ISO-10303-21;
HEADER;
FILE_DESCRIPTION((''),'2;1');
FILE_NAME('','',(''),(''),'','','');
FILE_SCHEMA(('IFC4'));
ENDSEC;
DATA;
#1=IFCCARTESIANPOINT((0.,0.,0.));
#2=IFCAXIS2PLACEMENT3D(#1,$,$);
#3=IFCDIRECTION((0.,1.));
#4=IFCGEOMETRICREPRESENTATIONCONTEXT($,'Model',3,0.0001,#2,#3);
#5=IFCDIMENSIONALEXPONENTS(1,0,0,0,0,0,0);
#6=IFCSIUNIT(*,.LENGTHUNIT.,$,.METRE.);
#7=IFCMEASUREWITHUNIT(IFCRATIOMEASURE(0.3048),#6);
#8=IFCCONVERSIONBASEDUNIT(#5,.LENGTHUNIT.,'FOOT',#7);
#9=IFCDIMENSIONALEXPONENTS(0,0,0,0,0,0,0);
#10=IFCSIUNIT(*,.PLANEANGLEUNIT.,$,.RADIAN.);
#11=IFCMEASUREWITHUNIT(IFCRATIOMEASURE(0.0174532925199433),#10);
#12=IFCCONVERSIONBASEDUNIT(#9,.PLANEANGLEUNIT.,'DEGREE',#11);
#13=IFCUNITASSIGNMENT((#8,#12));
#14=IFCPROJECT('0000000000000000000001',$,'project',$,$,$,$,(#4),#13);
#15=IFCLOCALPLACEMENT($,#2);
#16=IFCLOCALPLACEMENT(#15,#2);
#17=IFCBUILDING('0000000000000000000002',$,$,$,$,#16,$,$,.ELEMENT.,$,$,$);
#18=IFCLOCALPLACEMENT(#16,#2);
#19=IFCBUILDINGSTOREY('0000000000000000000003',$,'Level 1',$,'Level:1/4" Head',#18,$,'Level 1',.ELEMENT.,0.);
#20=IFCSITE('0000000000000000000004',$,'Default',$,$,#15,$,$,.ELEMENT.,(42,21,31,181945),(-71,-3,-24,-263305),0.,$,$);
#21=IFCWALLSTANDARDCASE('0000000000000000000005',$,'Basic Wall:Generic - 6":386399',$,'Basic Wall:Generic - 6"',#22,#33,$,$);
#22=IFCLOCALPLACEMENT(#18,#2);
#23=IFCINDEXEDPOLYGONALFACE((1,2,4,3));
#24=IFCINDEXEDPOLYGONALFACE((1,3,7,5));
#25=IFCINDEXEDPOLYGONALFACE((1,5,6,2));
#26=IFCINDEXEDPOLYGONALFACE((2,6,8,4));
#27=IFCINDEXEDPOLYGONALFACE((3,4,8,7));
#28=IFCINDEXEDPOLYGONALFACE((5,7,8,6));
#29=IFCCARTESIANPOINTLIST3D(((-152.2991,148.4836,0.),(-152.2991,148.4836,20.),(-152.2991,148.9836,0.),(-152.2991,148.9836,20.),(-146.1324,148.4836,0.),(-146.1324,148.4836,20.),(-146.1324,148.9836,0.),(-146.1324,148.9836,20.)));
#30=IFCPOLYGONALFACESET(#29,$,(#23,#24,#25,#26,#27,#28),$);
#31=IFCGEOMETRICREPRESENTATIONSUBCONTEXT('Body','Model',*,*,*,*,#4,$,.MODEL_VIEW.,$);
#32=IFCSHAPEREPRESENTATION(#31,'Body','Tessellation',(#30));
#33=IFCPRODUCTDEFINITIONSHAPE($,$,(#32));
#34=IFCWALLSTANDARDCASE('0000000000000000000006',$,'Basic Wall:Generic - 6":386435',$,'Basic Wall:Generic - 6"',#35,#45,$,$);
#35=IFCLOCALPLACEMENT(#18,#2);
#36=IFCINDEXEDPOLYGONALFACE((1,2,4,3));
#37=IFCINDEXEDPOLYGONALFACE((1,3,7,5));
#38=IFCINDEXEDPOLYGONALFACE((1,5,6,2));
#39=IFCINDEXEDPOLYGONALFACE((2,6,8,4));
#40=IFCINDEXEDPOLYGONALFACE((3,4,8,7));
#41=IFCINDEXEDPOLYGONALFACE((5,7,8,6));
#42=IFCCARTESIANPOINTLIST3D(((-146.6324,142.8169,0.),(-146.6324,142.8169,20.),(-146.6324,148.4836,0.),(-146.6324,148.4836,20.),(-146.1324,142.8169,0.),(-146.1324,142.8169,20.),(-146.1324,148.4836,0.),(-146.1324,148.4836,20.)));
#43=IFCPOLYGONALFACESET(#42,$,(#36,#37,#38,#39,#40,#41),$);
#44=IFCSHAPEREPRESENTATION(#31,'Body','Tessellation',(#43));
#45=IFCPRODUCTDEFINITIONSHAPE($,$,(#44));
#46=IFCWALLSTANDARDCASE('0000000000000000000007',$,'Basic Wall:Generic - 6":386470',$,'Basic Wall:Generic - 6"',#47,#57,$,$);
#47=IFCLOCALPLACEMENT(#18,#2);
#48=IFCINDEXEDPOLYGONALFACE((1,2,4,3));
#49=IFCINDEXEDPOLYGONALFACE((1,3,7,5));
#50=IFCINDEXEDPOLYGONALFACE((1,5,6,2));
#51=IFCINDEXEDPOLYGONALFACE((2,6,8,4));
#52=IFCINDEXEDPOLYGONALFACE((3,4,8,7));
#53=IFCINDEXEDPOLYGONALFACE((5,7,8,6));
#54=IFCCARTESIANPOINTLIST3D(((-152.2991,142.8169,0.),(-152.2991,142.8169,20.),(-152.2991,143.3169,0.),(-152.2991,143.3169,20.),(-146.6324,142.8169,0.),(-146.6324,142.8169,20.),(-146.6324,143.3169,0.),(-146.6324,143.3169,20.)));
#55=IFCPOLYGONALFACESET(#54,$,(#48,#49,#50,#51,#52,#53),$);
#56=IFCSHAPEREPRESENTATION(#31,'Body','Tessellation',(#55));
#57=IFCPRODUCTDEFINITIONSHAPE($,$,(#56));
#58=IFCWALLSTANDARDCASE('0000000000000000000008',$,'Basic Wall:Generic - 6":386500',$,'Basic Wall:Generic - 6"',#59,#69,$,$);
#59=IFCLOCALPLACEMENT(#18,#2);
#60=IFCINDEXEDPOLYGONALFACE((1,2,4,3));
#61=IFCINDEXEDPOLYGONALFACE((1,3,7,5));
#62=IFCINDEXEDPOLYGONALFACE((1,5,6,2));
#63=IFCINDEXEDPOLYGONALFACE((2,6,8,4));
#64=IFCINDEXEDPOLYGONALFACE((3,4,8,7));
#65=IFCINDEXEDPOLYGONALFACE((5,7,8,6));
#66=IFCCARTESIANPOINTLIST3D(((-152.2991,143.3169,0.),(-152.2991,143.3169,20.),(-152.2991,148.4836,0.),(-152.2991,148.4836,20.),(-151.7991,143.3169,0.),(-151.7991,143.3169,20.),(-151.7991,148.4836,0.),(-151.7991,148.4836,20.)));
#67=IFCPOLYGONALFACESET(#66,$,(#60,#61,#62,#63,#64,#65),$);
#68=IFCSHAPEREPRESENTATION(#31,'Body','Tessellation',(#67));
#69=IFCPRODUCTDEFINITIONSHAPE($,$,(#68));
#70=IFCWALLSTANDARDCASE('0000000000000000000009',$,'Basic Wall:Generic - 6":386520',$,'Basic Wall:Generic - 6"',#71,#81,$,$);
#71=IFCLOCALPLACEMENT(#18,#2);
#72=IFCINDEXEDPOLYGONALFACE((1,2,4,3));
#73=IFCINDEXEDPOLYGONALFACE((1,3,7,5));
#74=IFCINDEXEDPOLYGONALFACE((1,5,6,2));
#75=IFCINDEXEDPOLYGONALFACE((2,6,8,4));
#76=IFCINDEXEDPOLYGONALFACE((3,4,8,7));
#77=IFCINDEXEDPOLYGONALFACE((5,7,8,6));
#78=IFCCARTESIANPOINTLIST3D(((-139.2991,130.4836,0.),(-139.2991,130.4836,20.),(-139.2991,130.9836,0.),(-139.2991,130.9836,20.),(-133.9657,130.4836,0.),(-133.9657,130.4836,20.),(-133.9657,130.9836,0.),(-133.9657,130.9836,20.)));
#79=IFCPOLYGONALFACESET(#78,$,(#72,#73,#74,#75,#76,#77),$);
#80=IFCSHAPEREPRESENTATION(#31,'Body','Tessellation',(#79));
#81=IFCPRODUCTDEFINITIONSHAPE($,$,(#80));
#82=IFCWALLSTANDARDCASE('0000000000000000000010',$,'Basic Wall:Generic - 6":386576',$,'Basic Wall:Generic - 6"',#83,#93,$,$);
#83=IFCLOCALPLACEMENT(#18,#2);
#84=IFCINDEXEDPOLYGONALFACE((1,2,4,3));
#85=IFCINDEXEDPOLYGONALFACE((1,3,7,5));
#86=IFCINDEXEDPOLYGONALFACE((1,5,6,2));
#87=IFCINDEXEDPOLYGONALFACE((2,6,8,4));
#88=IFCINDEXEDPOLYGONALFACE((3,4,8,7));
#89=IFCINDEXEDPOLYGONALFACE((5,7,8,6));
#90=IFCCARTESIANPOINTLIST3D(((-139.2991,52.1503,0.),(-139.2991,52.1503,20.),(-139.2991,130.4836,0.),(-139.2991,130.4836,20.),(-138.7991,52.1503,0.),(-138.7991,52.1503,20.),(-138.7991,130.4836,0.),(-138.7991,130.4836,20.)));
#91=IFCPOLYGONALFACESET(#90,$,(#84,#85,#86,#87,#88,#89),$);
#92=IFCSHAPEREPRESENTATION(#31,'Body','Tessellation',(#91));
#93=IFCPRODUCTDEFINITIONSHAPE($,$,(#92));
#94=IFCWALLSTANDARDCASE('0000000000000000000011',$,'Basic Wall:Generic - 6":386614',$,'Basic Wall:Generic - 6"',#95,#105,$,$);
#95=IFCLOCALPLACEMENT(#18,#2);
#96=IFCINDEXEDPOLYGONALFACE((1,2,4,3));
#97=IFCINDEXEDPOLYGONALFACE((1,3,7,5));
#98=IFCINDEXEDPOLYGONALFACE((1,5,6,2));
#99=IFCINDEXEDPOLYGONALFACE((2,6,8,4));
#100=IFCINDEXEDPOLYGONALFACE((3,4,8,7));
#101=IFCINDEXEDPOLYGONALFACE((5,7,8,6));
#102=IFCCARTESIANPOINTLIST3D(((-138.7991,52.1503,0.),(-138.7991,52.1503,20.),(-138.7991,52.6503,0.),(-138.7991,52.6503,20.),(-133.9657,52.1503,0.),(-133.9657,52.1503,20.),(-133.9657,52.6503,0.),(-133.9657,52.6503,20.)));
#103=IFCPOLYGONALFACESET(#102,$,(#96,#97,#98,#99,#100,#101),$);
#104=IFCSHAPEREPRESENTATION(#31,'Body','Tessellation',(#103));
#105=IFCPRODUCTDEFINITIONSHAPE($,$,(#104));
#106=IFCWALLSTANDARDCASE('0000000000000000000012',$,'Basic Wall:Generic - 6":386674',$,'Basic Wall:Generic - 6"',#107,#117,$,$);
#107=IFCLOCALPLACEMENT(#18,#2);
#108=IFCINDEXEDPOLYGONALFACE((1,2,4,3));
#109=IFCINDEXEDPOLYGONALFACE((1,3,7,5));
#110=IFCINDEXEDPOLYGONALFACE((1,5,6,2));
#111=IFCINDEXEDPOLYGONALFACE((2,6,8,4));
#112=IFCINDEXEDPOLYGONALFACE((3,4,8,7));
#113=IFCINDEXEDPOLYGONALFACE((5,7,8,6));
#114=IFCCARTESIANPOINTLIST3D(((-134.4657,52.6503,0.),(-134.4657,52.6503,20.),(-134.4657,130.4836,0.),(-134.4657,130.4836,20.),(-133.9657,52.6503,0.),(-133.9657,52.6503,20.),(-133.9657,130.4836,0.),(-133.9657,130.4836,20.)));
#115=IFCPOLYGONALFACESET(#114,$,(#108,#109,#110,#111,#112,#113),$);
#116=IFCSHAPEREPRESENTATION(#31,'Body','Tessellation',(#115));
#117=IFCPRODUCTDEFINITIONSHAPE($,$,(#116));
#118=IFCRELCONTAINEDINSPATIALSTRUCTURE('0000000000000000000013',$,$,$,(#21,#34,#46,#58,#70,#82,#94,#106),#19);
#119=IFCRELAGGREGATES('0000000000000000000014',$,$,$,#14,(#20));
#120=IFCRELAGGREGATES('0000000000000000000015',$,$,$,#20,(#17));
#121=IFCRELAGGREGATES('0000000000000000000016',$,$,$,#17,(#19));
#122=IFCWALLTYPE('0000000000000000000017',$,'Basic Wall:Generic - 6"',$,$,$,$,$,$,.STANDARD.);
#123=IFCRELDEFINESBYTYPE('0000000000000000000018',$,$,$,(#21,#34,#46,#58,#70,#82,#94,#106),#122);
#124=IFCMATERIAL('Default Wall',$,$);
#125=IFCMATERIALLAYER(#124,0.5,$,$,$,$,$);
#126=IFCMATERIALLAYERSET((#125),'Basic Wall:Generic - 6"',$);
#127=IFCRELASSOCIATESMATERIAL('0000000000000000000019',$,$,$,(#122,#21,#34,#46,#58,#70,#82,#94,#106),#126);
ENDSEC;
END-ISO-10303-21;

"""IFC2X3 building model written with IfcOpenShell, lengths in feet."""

from ifc_helpers import new_model, entity, si_unit, converted_unit, direction, frame, frame_2d, origin, place, context, subcontext, project, spatial, rectangle, extrude, material, layer, layer_set, layer_usage, type_object, element, save


model = new_model("IFC2X3")

# Units and contexts
model_context = context("Model", 3, precision=0.0001, world=origin(), true_north=direction((0.0, 1.0)))
body_context = subcontext(model_context, "Body", "Model", "MODEL_VIEW")
ifc_project = project(units=[converted_unit("LENGTHUNIT", "FOOT", entity("IfcRatioMeasure", 0.3048), si_unit("LENGTHUNIT", "METRE"), dimensions=[1, 0, 0, 0, 0, 0, 0]), converted_unit("PLANEANGLEUNIT", "DEGREE", entity("IfcRatioMeasure", 0.0174532925199433), si_unit("PLANEANGLEUNIT", "RADIAN"), dimensions=[0, 0, 0, 0, 0, 0, 0])], contexts=[model_context])

# Site, building, storey
site_placement = place(None, origin())
site = spatial("IfcSite", under=ifc_project, at=site_placement, Name="Default", CompositionType="ELEMENT", RefLatitude=(42, 21, 31, 181945), RefLongitude=(-71, -3, -24, -263305), RefElevation=0.0)
building_placement = place(site_placement, origin())
building = spatial("IfcBuilding", under=site, at=building_placement, CompositionType="ELEMENT")
storey_placement = place(building_placement, origin())
storey = spatial("IfcBuildingStorey", under=building, at=storey_placement, Name="Level 1", ObjectType="Level:1/4\" Head", LongName="Level 1", CompositionType="ELEMENT", Elevation=0.0)

# Walls
ifc_material = material(Name="Default Wall")
ifc_layer_1 = layer(ifc_material, 0.5)
ifc_layer_set_1 = layer_set([ifc_layer_1], Name="Basic Wall:Generic - 6\"")
wall_type_1 = type_object("IfcWallType", Name="Basic Wall:Generic - 6\"", PredefinedType="STANDARD", material=ifc_layer_set_1)
ifc_layer_usage_1 = layer_usage(ifc_layer_set_1, "AXIS2", "NEGATIVE", 0.25)
wall_1_placement = place(storey_placement, frame((-152.2991, 148.7336, 0.0)))
element("IfcWallStandardCase", 1, at=wall_1_placement, inside=storey, type_object=wall_type_1, material=ifc_layer_usage_1, Name="Basic Wall:Generic - 6\":386399", ObjectType="Basic Wall:Generic - 6\"", context=body_context, shape_type="SweptSolid", body=[
    extrude(rectangle(XDim=6.1667, YDim=0.5, at=frame_2d((3.0833, 0.0), x_axis=(-1.0, 0.0))), origin(), (0.0, 0.0, 1.0), 20.0),
])
ifc_layer_usage_2 = layer_usage(ifc_layer_set_1, "AXIS2", "NEGATIVE", 0.25)
wall_2_placement = place(storey_placement, frame((-146.3824, 148.4836, 0.0), z_axis=(0.0, 0.0, 1.0), x_axis=(0.0, -1.0, 0.0)))
element("IfcWallStandardCase", 2, at=wall_2_placement, inside=storey, type_object=wall_type_1, material=ifc_layer_usage_2, Name="Basic Wall:Generic - 6\":386435", ObjectType="Basic Wall:Generic - 6\"", context=body_context, shape_type="SweptSolid", body=[
    extrude(rectangle(XDim=5.6667, YDim=0.5, at=frame_2d((2.8333, 0.0), x_axis=(-1.0, 0.0))), origin(), (0.0, 0.0, 1.0), 20.0),
])
ifc_layer_usage_3 = layer_usage(ifc_layer_set_1, "AXIS2", "NEGATIVE", 0.25)
wall_3_placement = place(storey_placement, frame((-146.6324, 143.0669, 0.0), z_axis=(0.0, 0.0, 1.0), x_axis=(-1.0, 0.0, 0.0)))
element("IfcWallStandardCase", 3, at=wall_3_placement, inside=storey, type_object=wall_type_1, material=ifc_layer_usage_3, Name="Basic Wall:Generic - 6\":386470", ObjectType="Basic Wall:Generic - 6\"", context=body_context, shape_type="SweptSolid", body=[
    extrude(rectangle(XDim=5.6667, YDim=0.5, at=frame_2d((2.8333, 0.0), x_axis=(-1.0, 0.0))), origin(), (0.0, 0.0, 1.0), 20.0),
])
ifc_layer_usage_4 = layer_usage(ifc_layer_set_1, "AXIS2", "NEGATIVE", 0.25)
wall_4_placement = place(storey_placement, frame((-152.0491, 143.3169, 0.0), z_axis=(0.0, 0.0, 1.0), x_axis=(0.0, 1.0, 0.0)))
element("IfcWallStandardCase", 4, at=wall_4_placement, inside=storey, type_object=wall_type_1, material=ifc_layer_usage_4, Name="Basic Wall:Generic - 6\":386500", ObjectType="Basic Wall:Generic - 6\"", context=body_context, shape_type="SweptSolid", body=[
    extrude(rectangle(XDim=5.1667, YDim=0.5, at=frame_2d((2.5833, 0.0), x_axis=(-1.0, 0.0))), origin(), (0.0, 0.0, 1.0), 20.0),
])
ifc_layer_usage_5 = layer_usage(ifc_layer_set_1, "AXIS2", "NEGATIVE", 0.25)
wall_5_placement = place(storey_placement, frame((-133.9657, 130.7336, 0.0), z_axis=(0.0, 0.0, 1.0), x_axis=(-1.0, 0.0, 0.0)))
element("IfcWallStandardCase", 5, at=wall_5_placement, inside=storey, type_object=wall_type_1, material=ifc_layer_usage_5, Name="Basic Wall:Generic - 6\":386520", ObjectType="Basic Wall:Generic - 6\"", context=body_context, shape_type="SweptSolid", body=[
    extrude(rectangle(XDim=5.3333, YDim=0.5, at=frame_2d((2.6667, 0.0), x_axis=(-1.0, 0.0))), origin(), (0.0, 0.0, 1.0), 20.0),
])
ifc_layer_usage_6 = layer_usage(ifc_layer_set_1, "AXIS2", "NEGATIVE", 0.25)
wall_6_placement = place(storey_placement, frame((-139.0491, 130.4836, 0.0), z_axis=(0.0, 0.0, 1.0), x_axis=(0.0, -1.0, 0.0)))
element("IfcWallStandardCase", 6, at=wall_6_placement, inside=storey, type_object=wall_type_1, material=ifc_layer_usage_6, Name="Basic Wall:Generic - 6\":386576", ObjectType="Basic Wall:Generic - 6\"", context=body_context, shape_type="SweptSolid", body=[
    extrude(rectangle(XDim=78.3333, YDim=0.5, at=frame_2d((39.1667, 0.0), x_axis=(-1.0, 0.0))), origin(), (0.0, 0.0, 1.0), 20.0),
])
ifc_layer_usage_7 = layer_usage(ifc_layer_set_1, "AXIS2", "NEGATIVE", 0.25)
wall_7_placement = place(storey_placement, frame((-138.7991, 52.4003, 0.0)))
element("IfcWallStandardCase", 7, at=wall_7_placement, inside=storey, type_object=wall_type_1, material=ifc_layer_usage_7, Name="Basic Wall:Generic - 6\":386614", ObjectType="Basic Wall:Generic - 6\"", context=body_context, shape_type="SweptSolid", body=[
    extrude(rectangle(XDim=4.8333, YDim=0.5, at=frame_2d((2.4167, 0.0), x_axis=(-1.0, 0.0))), origin(), (0.0, 0.0, 1.0), 20.0),
])
ifc_layer_usage_8 = layer_usage(ifc_layer_set_1, "AXIS2", "NEGATIVE", 0.25)
wall_8_placement = place(storey_placement, frame((-134.2157, 52.6503, 0.0), z_axis=(0.0, 0.0, 1.0), x_axis=(0.0, 1.0, 0.0)))
element("IfcWallStandardCase", 8, at=wall_8_placement, inside=storey, type_object=wall_type_1, material=ifc_layer_usage_8, Name="Basic Wall:Generic - 6\":386674", ObjectType="Basic Wall:Generic - 6\"", context=body_context, shape_type="SweptSolid", body=[
    extrude(rectangle(XDim=77.8333, YDim=0.5, at=frame_2d((38.9167, 0.0), x_axis=(-1.0, 0.0))), origin(), (0.0, 0.0, 1.0), 20.0),
])

save(model, "model.ifc")
